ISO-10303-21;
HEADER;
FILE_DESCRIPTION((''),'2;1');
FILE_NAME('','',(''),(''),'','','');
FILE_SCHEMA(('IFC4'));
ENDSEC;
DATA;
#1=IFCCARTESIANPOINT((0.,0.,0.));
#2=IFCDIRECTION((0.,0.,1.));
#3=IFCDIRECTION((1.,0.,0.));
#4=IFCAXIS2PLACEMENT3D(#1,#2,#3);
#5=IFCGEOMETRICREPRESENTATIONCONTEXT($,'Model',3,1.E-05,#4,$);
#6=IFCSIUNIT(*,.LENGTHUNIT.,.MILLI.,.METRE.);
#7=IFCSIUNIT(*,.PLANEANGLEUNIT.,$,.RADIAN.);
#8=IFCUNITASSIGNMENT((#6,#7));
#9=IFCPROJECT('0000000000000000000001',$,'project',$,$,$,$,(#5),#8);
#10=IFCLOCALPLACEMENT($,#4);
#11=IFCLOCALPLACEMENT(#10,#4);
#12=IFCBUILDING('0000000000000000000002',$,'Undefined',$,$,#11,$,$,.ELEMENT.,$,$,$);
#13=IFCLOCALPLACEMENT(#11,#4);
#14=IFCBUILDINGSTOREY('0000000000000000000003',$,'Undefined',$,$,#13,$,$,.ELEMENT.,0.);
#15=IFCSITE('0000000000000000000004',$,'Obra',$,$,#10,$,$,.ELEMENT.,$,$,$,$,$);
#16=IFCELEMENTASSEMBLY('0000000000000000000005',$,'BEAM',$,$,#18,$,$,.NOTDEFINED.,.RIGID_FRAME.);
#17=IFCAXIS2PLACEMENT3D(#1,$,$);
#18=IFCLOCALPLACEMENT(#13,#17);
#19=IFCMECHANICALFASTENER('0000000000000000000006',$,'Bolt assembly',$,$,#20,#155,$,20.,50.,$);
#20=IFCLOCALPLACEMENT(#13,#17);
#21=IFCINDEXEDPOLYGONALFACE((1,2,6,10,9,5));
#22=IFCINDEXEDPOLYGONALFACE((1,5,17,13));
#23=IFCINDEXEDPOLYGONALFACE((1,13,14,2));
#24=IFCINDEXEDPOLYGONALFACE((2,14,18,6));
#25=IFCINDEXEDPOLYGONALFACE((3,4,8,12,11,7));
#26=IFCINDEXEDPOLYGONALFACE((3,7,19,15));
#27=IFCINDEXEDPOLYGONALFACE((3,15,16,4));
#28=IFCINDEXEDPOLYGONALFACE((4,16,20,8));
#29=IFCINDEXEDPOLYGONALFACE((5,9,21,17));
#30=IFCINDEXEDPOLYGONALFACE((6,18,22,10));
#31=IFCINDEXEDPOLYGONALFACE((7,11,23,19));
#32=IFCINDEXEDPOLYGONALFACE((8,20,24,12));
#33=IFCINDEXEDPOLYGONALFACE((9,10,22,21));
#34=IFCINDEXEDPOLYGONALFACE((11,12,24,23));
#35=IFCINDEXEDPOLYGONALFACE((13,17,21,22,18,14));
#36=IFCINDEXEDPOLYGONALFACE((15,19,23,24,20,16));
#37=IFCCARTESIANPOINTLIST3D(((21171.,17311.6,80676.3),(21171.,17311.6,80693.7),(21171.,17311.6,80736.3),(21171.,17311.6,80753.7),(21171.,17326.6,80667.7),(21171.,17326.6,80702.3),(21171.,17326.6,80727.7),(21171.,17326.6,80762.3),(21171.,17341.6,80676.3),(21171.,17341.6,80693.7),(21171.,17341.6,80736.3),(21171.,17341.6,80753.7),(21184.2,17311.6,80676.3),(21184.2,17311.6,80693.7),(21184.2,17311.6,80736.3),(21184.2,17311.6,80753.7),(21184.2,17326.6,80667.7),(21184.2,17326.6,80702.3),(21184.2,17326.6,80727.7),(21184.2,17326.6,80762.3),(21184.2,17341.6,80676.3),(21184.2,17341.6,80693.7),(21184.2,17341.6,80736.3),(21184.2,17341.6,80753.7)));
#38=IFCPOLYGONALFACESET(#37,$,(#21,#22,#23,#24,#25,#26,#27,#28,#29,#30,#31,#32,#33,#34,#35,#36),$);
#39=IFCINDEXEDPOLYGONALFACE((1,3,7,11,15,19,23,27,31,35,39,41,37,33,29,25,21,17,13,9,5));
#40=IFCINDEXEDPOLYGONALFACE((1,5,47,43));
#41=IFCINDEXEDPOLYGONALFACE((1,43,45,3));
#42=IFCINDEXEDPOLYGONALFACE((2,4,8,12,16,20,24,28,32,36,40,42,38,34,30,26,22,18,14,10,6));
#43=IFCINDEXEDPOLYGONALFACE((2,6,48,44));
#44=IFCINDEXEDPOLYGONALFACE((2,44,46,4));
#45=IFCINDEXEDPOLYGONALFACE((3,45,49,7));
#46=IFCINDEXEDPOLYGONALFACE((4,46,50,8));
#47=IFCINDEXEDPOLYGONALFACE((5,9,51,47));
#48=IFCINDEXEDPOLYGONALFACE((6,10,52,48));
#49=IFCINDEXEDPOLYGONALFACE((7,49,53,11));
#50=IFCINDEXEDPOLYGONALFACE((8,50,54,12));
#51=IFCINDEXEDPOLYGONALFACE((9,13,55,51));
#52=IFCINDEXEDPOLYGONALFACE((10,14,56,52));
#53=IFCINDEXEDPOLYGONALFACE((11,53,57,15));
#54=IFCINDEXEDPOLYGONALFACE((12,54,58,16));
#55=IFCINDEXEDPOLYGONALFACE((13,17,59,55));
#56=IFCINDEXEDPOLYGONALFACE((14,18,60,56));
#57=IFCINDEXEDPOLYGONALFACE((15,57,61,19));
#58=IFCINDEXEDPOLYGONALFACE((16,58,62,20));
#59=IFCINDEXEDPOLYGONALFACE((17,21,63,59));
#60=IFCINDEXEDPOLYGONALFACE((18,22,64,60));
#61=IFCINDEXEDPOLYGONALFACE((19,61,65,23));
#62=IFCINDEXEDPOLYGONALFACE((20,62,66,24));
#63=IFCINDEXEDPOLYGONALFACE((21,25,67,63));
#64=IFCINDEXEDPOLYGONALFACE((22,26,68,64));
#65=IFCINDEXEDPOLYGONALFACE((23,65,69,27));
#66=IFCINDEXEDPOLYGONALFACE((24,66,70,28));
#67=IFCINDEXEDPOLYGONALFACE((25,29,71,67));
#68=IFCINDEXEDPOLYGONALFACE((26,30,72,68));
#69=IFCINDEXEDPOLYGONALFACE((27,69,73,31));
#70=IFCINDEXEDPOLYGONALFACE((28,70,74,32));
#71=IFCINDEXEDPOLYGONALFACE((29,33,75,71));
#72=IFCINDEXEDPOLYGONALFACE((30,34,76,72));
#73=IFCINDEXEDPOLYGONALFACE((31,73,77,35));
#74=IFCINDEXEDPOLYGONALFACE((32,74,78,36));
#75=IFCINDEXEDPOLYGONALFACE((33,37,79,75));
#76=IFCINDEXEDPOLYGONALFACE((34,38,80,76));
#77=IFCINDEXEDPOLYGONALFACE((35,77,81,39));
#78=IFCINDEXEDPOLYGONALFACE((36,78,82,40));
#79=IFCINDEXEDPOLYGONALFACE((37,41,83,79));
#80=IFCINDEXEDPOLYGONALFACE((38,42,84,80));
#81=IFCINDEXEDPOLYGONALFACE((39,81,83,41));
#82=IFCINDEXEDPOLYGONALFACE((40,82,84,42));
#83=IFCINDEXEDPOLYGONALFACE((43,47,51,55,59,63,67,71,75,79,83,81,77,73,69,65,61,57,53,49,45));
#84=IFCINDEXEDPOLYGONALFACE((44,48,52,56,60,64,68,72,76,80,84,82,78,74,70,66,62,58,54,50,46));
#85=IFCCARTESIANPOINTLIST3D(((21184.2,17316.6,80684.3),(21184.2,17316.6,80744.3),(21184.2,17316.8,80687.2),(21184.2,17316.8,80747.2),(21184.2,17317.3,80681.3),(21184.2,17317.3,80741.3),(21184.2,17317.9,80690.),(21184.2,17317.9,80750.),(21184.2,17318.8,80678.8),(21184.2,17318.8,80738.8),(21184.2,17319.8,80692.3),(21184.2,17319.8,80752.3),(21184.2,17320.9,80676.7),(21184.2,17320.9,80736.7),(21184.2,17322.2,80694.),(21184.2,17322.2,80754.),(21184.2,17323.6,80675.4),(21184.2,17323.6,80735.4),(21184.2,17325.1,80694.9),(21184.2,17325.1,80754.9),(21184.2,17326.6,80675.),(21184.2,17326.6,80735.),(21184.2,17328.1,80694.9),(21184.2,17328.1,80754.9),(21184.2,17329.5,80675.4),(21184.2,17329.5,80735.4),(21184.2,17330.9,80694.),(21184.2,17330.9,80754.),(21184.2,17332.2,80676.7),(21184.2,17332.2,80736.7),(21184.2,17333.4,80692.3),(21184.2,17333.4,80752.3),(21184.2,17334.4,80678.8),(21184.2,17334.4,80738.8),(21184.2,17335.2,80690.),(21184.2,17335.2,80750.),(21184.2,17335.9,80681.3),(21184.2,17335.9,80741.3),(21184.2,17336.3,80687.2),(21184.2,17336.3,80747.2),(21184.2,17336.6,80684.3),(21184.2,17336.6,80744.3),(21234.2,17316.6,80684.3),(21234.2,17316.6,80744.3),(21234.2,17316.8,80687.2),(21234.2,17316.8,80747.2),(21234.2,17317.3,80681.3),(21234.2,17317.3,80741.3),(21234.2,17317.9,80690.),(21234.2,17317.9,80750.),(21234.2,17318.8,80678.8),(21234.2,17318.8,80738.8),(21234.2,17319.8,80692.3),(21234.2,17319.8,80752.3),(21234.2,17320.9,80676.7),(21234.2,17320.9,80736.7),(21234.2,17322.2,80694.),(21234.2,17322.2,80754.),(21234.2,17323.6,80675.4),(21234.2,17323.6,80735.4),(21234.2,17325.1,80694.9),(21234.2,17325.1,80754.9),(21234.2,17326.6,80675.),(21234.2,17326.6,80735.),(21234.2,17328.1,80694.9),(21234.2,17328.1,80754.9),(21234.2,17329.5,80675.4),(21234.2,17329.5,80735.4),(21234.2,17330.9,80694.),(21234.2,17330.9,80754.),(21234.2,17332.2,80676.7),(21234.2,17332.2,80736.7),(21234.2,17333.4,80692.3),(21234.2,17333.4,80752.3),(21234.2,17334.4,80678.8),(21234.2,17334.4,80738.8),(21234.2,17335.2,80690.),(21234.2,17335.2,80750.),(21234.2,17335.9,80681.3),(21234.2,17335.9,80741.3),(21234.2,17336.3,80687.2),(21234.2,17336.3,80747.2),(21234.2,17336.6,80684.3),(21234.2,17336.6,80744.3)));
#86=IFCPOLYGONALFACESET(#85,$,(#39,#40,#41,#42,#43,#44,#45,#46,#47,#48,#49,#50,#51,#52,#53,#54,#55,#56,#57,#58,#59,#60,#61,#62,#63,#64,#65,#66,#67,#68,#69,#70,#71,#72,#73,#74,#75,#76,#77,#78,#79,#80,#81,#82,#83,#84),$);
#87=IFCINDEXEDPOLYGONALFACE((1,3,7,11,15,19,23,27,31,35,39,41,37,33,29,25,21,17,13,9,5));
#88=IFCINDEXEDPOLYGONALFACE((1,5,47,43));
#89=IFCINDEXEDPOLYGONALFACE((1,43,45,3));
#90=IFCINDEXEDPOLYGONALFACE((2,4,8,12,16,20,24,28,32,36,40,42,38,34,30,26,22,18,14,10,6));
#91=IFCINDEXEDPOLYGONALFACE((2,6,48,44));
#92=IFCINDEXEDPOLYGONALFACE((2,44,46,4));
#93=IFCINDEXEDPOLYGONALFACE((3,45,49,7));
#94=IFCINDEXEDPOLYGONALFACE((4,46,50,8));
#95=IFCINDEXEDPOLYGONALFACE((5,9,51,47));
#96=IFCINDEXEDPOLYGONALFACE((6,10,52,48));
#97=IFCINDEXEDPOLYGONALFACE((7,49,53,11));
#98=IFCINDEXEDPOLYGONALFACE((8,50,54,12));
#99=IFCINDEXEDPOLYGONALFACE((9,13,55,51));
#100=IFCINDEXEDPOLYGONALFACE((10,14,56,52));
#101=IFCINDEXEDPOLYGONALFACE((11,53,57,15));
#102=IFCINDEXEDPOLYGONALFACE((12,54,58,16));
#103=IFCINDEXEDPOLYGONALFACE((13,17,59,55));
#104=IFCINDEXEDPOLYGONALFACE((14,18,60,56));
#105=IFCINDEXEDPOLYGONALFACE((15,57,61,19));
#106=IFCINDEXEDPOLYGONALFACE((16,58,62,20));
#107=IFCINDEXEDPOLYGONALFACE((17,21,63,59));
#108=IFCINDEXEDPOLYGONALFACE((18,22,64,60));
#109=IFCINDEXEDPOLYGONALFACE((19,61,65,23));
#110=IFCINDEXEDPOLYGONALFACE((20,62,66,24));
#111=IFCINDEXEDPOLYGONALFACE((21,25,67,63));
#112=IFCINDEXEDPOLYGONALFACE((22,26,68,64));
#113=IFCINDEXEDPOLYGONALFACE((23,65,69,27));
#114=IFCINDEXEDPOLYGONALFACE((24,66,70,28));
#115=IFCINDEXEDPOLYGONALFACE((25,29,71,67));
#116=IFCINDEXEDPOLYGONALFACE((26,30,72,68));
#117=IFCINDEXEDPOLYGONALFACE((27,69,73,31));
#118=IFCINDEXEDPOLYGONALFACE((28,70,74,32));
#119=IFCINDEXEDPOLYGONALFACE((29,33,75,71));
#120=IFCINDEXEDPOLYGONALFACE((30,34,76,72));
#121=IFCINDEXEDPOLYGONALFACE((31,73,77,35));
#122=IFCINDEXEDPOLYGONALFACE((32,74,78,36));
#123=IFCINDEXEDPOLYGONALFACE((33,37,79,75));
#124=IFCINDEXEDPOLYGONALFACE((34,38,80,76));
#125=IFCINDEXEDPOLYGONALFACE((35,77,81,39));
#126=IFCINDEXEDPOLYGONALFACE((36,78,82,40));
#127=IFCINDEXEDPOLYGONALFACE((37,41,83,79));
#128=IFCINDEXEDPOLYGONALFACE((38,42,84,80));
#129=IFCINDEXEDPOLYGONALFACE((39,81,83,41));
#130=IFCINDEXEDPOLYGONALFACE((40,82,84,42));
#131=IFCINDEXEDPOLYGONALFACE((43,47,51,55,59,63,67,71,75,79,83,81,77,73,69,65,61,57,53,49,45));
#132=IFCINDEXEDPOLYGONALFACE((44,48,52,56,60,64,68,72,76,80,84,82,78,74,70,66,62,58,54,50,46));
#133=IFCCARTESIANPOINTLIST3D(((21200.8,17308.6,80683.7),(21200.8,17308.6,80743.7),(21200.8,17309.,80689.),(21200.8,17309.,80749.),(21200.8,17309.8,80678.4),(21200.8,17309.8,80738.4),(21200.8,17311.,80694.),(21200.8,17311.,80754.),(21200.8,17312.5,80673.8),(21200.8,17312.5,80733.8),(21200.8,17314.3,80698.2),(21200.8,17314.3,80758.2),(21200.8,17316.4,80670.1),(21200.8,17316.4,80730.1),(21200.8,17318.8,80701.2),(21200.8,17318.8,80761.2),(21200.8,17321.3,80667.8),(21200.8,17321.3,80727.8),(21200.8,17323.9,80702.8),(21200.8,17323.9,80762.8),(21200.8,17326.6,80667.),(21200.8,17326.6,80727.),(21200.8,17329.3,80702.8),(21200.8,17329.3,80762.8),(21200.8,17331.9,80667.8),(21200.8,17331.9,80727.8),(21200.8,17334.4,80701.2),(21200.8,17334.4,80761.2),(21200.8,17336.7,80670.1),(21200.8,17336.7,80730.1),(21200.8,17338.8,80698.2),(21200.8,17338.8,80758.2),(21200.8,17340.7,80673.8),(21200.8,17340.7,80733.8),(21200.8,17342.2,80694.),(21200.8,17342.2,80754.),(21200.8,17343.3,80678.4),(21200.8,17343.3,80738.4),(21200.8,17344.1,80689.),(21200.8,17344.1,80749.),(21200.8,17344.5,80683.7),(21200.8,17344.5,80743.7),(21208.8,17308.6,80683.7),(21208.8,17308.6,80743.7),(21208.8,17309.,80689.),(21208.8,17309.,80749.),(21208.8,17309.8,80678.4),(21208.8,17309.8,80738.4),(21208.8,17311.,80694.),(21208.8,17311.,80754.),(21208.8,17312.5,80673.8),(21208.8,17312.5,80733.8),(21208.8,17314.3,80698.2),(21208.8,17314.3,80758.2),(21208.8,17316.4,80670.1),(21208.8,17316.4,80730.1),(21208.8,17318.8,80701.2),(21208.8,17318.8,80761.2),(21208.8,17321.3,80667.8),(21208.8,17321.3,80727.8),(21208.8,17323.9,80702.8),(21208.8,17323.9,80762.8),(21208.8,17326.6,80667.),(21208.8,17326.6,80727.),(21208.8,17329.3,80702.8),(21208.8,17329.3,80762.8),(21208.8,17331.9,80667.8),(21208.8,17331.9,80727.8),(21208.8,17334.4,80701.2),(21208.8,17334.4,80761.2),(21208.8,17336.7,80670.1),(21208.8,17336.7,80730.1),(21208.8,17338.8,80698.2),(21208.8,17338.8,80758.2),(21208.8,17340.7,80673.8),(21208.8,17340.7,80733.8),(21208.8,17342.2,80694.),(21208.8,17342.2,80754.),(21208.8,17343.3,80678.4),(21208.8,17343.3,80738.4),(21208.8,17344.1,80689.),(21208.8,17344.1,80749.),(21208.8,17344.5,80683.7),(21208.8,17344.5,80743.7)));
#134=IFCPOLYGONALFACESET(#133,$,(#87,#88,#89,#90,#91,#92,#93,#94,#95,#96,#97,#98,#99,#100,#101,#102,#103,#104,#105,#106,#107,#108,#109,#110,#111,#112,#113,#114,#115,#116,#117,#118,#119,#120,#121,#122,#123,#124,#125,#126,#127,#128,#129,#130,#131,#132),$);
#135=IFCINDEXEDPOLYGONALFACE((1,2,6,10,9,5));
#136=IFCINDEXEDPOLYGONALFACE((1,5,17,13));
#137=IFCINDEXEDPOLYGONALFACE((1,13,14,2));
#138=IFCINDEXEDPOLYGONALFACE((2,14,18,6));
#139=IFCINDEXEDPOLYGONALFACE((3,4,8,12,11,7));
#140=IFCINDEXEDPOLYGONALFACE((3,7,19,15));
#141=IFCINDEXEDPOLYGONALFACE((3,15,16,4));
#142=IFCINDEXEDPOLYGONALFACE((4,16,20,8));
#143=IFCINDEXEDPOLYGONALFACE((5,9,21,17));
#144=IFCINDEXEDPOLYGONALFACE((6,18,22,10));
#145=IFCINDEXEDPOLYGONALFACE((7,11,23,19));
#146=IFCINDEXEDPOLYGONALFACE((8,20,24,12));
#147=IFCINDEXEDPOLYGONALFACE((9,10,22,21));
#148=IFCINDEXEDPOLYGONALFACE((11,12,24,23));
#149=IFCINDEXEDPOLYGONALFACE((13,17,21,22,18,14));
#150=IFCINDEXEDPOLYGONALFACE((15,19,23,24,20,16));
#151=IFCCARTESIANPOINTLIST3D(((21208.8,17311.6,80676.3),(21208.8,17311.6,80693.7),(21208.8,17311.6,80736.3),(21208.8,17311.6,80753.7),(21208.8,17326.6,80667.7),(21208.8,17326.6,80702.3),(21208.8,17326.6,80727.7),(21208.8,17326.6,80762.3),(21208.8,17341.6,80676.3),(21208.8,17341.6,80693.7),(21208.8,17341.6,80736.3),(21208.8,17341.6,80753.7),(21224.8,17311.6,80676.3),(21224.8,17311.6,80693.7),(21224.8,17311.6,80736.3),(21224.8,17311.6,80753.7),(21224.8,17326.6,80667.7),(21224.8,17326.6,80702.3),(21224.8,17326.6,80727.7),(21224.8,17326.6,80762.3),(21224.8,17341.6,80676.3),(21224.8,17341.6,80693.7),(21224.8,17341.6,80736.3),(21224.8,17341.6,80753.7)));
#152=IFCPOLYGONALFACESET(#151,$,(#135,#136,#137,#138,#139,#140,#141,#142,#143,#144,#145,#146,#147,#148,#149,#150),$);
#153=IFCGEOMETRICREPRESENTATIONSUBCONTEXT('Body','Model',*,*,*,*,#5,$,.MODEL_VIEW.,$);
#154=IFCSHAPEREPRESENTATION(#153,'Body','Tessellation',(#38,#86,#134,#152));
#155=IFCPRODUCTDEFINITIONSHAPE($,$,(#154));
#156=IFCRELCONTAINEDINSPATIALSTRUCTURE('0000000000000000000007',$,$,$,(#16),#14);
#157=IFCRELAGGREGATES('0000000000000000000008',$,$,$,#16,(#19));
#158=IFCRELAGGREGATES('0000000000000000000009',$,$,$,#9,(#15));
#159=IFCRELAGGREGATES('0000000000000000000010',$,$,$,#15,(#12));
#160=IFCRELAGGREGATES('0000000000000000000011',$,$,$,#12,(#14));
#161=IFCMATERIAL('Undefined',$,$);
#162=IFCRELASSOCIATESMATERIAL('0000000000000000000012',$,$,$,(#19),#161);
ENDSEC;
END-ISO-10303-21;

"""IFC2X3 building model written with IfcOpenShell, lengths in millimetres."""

from ifc_helpers import new_model, si_unit, frame, origin_with_axes, origin_2d_with_axis, place, context, subcontext, project, spatial, polyline, circle, outline, extrude, source, transform, mapped, material, element, aggregate, save


model = new_model("IFC2X3")

# Units and contexts
model_context = context("Model", 3, precision=1e-05, world=origin_with_axes())
body_context = subcontext(model_context, "Body", "Model", "MODEL_VIEW")
ifc_project = project(units=[si_unit("LENGTHUNIT", "METRE", prefix="MILLI"), si_unit("PLANEANGLEUNIT", "RADIAN")], contexts=[model_context])

# Site, building, storey
site_placement = place(None, origin_with_axes())
site = spatial("IfcSite", under=ifc_project, at=site_placement, Name="Obra", CompositionType="ELEMENT")
building_placement = place(site_placement, origin_with_axes())
building = spatial("IfcBuilding", under=site, at=building_placement, Name="Undefined", CompositionType="ELEMENT")
storey_placement = place(building_placement, origin_with_axes())
storey = spatial("IfcBuildingStorey", under=building, at=storey_placement, Name="Undefined", CompositionType="ELEMENT", Elevation=0.0)

# Element assembly, mechanical fastener
ifc_material_1 = material(Name="Undefined")
shared_shape_1 = source(origin_with_axes(), body_context, "Body", "SweptSolid", [
    extrude(outline(polyline([(17.3, 0.0), (8.7, 15.0), (-8.7, 15.0), (-17.3, 0.0), (-8.7, -15.0), (8.7, -15.0), (17.3, 0.0)])), frame((0.0, -26.5, 0.0), z_axis=(0.0, 1.0, 0.0), x_axis=(1.0, 0.0, 0.0)), (0.0, 0.0, 1.0), 13.2),
    extrude(circle(Radius=10.0, at=origin_2d_with_axis()), frame((0.0, -13.3, 0.0), z_axis=(0.0, 1.0, 0.0), x_axis=(1.0, 0.0, 0.0)), (0.0, 0.0, 1.0), 50.0),
    extrude(circle(Radius=18.0, at=origin_2d_with_axis()), frame((0.0, 3.3, 0.0), z_axis=(0.0, 1.0, 0.0), x_axis=(1.0, 0.0, 0.0)), (0.0, 0.0, 1.0), 8.0),
    extrude(outline(polyline([(17.3, 0.0), (8.7, 15.0), (-8.7, 15.0), (-17.3, 0.0), (-8.7, -15.0), (8.7, -15.0), (17.3, 0.0)])), frame((0.0, 11.3, 0.0), z_axis=(0.0, 1.0, 0.0), x_axis=(1.0, 0.0, 0.0)), (0.0, 0.0, 1.0), 16.0),
])
assembly_1_placement = place(storey_placement, origin_with_axes())
assembly_1 = element("IfcElementAssembly", 1, at=assembly_1_placement, inside=storey, Name="BEAM", AssemblyPlace="NOTDEFINED", PredefinedType="RIGID_FRAME")
mechanical_fastener_1_placement = place(assembly_1_placement, frame((21197.5, 17366.6, 80850.0), z_axis=(0.0, -1.0, 0.0), x_axis=(0.0, 0.0, -1.0)))
mechanical_fastener_1 = element("IfcMechanicalFastener", 2, at=mechanical_fastener_1_placement, material=ifc_material_1, Name="Bolt assembly", NominalDiameter=20.0, NominalLength=50.0, context=body_context, shape_type="MappedRepresentation", body=[
    mapped(shared_shape_1, transform((105.0, 0.0, 40.0))),
    mapped(shared_shape_1, transform((165.0, 0.0, 40.0))),
])

aggregate(assembly_1, [mechanical_fastener_1])

save(model, "model.ifc")
